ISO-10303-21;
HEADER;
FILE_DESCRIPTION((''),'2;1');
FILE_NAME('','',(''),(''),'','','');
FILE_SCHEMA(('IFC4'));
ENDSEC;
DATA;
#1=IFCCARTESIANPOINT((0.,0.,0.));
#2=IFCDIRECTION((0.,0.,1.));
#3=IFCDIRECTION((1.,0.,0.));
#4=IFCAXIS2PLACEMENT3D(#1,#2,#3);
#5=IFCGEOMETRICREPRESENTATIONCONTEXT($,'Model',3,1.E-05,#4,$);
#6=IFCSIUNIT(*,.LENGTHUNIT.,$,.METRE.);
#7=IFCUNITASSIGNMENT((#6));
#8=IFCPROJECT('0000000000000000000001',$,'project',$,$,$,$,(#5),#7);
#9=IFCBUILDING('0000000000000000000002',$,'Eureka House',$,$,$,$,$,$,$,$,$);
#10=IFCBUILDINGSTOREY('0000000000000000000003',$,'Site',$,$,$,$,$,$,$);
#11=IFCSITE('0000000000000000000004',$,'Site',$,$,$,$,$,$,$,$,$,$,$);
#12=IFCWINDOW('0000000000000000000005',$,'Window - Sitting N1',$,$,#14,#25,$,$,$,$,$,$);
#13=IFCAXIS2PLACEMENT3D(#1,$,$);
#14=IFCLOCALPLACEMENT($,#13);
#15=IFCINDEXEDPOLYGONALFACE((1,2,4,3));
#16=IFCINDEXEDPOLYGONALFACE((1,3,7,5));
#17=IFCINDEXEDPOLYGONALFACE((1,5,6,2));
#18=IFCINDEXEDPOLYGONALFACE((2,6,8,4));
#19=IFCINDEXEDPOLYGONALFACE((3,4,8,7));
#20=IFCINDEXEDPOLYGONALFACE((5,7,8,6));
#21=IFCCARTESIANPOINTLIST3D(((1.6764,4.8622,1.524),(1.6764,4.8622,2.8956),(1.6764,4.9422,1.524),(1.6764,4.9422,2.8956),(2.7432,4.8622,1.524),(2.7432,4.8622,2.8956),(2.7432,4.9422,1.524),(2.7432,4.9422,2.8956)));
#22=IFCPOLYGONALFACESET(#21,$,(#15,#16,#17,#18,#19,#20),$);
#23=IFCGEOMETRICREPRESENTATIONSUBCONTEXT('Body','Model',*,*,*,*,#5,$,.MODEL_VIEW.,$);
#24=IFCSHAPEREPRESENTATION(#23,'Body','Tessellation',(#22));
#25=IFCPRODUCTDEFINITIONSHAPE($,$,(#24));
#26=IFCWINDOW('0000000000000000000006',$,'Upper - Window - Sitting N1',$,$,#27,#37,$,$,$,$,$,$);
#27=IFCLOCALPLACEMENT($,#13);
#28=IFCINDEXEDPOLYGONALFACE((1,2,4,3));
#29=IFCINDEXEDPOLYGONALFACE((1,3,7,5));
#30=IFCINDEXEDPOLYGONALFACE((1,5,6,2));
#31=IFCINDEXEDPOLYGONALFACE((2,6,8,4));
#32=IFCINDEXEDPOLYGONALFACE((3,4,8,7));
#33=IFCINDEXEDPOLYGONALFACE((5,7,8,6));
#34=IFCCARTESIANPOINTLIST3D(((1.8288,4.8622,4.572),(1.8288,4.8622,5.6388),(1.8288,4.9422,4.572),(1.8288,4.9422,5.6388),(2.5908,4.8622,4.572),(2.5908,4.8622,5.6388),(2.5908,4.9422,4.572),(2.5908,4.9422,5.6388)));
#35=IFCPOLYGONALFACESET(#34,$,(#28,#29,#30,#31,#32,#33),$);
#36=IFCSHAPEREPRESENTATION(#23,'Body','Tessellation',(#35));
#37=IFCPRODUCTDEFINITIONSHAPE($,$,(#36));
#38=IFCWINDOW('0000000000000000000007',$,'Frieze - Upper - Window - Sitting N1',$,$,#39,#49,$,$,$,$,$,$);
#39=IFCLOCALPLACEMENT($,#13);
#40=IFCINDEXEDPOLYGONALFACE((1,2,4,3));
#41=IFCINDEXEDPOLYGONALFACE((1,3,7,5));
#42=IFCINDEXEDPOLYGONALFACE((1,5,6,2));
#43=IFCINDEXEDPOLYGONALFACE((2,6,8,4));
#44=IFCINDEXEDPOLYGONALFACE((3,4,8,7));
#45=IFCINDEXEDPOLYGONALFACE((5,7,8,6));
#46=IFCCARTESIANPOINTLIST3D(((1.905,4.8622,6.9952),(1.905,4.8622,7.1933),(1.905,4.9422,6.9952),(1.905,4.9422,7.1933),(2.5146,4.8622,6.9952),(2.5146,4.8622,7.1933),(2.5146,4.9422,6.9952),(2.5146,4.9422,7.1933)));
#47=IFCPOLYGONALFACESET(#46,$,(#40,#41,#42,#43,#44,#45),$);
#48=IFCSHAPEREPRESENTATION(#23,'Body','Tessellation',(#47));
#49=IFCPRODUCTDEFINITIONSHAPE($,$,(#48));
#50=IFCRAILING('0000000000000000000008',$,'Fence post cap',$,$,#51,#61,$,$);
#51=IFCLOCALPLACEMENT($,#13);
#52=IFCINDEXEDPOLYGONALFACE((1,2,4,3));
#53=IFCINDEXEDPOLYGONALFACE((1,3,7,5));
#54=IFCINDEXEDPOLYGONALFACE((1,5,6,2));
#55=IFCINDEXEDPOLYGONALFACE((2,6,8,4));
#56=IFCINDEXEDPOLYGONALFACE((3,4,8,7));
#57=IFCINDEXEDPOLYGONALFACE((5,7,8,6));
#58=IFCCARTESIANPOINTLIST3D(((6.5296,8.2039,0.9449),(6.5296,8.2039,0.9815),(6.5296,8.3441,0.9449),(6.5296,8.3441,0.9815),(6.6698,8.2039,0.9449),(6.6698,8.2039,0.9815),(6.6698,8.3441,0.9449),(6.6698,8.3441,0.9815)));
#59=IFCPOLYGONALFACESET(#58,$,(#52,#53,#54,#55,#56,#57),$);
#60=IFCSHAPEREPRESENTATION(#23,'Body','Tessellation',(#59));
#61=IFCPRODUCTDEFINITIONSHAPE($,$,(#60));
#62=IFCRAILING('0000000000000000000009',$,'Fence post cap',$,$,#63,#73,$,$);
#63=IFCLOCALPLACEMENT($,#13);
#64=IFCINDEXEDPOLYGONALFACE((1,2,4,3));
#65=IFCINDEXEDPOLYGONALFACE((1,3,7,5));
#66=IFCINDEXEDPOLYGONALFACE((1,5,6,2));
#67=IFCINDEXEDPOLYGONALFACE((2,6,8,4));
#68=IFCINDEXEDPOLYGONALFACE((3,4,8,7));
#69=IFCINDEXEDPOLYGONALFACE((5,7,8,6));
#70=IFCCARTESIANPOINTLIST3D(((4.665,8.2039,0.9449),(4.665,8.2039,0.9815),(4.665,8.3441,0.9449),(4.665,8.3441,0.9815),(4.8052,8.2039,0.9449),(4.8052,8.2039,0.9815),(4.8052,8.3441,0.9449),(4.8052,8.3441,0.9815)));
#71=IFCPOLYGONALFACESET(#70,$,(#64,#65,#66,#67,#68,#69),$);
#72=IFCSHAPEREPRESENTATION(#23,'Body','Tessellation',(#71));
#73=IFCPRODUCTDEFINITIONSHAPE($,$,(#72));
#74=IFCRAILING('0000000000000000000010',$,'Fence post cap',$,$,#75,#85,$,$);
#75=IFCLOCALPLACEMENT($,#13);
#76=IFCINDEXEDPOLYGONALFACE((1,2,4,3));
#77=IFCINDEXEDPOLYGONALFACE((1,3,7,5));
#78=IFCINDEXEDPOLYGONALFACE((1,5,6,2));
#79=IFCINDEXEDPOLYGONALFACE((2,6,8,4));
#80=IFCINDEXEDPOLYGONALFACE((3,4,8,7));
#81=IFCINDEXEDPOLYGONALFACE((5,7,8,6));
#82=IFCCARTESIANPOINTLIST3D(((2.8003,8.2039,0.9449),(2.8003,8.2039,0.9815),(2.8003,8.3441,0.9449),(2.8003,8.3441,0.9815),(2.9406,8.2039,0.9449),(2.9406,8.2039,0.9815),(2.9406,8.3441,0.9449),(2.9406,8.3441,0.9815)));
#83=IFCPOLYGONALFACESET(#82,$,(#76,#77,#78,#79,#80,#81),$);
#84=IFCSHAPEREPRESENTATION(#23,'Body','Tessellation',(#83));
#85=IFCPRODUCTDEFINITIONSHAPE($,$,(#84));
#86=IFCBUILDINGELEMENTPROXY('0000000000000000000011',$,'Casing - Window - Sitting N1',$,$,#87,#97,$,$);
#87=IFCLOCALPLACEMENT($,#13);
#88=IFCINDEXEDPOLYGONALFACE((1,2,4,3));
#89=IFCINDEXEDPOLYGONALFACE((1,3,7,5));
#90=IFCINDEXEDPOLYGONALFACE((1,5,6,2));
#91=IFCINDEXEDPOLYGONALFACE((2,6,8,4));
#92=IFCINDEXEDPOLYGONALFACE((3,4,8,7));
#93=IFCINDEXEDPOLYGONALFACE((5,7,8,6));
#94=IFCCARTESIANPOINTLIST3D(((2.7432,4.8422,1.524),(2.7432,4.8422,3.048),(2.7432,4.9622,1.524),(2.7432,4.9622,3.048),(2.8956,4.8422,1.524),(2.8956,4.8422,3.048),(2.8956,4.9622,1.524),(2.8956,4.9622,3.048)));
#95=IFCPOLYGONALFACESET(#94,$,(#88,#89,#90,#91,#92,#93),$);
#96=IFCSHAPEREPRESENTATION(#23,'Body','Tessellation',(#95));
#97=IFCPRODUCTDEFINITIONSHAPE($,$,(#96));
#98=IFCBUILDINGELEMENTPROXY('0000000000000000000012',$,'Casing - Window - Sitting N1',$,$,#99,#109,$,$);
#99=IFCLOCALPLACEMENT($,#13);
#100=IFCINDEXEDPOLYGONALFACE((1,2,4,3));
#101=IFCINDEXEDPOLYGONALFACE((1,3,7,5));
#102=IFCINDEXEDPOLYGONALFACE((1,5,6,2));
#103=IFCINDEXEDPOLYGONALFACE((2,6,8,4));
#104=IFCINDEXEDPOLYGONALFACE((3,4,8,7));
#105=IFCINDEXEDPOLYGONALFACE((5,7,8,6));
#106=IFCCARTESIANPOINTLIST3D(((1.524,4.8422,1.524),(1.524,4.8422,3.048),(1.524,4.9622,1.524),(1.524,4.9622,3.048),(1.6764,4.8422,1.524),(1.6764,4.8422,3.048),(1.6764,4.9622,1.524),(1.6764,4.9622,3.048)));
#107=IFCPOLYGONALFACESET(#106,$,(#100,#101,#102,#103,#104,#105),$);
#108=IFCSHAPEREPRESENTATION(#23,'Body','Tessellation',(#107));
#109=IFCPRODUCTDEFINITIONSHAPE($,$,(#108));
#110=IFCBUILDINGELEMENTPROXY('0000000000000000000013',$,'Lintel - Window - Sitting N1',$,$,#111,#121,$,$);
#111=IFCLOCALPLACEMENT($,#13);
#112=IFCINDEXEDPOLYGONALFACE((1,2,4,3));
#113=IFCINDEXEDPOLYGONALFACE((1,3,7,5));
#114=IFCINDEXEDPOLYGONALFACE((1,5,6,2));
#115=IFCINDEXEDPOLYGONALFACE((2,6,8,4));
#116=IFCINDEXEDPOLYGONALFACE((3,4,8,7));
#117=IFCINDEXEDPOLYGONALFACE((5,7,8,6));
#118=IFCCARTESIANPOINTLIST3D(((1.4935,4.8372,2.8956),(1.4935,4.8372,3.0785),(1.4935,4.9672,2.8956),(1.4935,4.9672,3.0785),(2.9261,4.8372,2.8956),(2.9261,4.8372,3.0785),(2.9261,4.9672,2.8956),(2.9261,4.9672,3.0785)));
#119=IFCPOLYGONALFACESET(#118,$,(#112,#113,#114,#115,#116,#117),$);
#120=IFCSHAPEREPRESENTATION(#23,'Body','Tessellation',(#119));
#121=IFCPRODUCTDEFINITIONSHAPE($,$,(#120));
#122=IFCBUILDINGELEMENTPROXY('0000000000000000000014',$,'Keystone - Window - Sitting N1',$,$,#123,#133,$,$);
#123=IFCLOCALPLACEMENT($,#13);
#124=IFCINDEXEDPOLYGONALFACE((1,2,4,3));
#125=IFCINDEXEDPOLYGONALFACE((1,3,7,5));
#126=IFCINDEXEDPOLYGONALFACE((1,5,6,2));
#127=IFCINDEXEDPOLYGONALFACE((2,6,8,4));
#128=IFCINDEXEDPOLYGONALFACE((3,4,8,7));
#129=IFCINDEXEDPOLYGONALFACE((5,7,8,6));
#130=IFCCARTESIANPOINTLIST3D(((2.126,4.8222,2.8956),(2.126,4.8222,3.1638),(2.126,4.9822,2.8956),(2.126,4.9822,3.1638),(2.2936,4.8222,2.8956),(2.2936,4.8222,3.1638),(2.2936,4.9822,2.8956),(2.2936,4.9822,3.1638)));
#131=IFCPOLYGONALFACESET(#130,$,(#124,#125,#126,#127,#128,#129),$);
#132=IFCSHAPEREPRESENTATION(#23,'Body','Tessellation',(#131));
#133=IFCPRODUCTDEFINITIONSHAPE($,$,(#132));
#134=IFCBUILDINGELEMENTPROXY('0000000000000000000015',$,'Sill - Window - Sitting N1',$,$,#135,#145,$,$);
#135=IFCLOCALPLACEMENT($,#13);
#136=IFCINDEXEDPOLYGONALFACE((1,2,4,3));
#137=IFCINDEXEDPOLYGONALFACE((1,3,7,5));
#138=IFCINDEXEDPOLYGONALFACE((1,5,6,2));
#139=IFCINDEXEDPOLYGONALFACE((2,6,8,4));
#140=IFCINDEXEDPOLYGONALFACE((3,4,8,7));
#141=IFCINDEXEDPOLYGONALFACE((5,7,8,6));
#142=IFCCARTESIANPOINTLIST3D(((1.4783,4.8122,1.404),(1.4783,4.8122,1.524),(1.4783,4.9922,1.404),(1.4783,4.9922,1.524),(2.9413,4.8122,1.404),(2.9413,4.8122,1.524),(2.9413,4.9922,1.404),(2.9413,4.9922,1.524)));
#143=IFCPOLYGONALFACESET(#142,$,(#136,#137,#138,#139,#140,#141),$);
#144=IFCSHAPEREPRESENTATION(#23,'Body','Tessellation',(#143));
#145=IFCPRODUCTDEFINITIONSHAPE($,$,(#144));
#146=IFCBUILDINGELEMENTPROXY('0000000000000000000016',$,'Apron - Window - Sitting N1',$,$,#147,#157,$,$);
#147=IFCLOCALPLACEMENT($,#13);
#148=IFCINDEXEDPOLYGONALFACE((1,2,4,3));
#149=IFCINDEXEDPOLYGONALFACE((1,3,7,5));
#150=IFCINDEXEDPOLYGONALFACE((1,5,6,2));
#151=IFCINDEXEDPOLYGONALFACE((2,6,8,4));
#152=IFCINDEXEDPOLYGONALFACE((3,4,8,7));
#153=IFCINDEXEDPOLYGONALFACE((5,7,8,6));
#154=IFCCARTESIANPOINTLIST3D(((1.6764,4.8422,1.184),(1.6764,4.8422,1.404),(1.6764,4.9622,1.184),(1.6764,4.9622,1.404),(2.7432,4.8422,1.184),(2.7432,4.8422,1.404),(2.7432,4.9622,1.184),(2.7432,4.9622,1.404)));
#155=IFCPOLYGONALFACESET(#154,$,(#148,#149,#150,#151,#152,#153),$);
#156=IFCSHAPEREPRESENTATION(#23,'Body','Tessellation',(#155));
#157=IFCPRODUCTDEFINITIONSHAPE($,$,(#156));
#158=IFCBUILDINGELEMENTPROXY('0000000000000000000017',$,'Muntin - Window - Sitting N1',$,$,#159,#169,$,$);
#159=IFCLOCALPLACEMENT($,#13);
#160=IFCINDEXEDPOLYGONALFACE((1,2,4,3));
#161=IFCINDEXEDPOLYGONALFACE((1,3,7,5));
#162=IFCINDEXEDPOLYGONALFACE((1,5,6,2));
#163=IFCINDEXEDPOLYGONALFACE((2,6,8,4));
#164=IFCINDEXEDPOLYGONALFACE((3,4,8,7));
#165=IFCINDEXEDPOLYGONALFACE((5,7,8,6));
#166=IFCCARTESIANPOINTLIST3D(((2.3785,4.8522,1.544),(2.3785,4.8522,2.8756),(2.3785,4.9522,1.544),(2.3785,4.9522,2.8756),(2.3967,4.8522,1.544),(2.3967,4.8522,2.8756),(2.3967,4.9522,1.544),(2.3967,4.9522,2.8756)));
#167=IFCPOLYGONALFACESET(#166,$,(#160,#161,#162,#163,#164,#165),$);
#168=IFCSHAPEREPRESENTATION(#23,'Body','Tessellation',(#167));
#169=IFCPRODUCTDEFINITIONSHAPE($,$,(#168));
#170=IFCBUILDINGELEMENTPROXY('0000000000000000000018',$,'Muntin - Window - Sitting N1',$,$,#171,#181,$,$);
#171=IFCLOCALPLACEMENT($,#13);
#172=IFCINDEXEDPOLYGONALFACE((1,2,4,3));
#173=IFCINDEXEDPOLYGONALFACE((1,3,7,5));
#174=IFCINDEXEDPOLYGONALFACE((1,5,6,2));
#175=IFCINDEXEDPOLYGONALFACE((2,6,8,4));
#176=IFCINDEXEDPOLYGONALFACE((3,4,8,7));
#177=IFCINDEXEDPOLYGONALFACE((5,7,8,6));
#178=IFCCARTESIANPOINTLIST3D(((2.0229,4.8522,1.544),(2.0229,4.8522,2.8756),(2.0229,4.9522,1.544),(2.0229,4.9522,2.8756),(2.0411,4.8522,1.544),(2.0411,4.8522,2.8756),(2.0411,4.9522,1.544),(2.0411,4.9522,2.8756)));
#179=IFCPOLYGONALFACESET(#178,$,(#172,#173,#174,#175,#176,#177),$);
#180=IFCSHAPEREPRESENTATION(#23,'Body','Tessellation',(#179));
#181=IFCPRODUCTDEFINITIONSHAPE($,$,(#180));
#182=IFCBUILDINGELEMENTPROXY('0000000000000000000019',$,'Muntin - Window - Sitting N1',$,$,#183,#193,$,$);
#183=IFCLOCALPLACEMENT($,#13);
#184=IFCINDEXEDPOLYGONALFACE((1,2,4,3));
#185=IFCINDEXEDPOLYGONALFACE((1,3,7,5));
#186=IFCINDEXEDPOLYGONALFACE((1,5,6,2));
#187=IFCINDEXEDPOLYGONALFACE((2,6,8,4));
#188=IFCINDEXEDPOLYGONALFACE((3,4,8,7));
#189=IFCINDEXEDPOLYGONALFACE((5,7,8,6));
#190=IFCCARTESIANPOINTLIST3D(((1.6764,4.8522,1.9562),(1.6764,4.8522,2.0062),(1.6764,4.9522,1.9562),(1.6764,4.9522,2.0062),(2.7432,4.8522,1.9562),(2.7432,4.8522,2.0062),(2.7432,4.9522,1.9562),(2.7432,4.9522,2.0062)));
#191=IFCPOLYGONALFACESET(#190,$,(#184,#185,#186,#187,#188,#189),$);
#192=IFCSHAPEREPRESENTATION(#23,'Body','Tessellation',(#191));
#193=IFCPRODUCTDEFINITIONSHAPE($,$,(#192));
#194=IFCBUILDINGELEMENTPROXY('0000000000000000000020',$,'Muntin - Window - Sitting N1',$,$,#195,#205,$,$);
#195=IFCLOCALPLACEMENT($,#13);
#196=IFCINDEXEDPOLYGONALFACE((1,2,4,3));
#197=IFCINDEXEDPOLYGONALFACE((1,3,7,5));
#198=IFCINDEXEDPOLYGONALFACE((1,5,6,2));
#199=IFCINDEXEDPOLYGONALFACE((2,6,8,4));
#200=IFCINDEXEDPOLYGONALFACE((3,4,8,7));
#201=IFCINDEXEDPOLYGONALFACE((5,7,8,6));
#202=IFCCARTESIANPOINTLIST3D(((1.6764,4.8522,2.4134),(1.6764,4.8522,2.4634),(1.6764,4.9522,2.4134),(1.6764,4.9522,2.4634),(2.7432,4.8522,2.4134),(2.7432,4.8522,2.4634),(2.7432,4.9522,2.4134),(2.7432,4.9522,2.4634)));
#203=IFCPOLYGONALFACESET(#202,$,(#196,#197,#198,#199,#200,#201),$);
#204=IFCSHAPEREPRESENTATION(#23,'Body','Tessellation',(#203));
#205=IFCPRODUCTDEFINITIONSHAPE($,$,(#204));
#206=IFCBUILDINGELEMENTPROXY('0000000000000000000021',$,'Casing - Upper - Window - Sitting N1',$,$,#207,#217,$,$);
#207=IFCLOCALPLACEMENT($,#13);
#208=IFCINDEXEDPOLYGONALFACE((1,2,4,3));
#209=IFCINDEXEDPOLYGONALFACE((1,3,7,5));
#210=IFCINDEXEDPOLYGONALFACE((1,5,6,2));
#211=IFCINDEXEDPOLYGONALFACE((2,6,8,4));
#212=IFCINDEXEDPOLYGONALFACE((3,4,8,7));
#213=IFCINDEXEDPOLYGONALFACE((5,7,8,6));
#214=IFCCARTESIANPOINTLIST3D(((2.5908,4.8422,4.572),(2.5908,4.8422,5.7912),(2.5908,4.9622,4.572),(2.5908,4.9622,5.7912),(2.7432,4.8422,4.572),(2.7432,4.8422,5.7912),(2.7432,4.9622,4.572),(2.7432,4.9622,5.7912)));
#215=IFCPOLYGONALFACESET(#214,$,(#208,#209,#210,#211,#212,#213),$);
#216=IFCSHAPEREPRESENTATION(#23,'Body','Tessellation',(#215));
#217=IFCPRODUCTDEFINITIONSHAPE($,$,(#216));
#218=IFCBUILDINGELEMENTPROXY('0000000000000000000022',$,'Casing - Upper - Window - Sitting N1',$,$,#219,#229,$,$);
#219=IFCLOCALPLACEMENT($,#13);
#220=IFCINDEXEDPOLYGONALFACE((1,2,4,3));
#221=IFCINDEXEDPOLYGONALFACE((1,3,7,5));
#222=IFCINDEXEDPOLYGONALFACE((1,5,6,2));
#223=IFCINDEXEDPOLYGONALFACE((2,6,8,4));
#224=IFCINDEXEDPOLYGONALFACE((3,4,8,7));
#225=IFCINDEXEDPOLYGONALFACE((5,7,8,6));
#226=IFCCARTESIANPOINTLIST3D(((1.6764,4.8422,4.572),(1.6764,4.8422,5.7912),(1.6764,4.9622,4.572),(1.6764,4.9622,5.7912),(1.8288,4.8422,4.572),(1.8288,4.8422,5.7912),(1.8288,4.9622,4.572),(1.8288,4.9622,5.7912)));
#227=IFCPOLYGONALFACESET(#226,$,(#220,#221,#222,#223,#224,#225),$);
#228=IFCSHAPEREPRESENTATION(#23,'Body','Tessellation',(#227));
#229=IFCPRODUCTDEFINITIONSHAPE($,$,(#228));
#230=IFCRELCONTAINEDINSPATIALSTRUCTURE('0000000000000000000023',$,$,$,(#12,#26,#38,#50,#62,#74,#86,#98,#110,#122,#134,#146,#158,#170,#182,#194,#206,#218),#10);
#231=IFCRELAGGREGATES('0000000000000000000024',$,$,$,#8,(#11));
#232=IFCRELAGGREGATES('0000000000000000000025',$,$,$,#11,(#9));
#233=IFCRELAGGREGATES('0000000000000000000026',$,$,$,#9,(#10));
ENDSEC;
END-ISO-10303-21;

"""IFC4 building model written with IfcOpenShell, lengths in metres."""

from ifc_helpers import new_model, si_unit, frame, origin, origin_with_axes, origin_2d, place, context, subcontext, project, spatial, rectangle, extrude, element, save


model = new_model("IFC4")

# Units and contexts
model_context = context("Model", 3, precision=1e-05, world=origin_with_axes())
body_context = subcontext(model_context, "Body", "Model", "MODEL_VIEW")
ifc_project = project(units=[si_unit("LENGTHUNIT", "METRE")], contexts=[model_context])

# Site, building, storey
site = spatial("IfcSite", under=ifc_project, Name="Site")
building = spatial("IfcBuilding", under=site, Name="Eureka House")
storey = spatial("IfcBuildingStorey", under=building, Name="Site")

# Windows
window_1_placement = place(None, frame((2.2098, 4.9022, 1.524), z_axis=(0.0, 0.0, 1.0), x_axis=(1.0, 0.0, 0.0)))
element("IfcWindow", 1, at=window_1_placement, inside=storey, Name="Window - Sitting N1", context=body_context, shape_type="SweptSolid", body=[
    extrude(rectangle(XDim=1.0668, YDim=0.08, at=origin_2d()), origin(), (0.0, 0.0, 1.0), 1.3716),
])
window_2_placement = place(None, frame((2.2098, 4.9022, 4.572), z_axis=(0.0, 0.0, 1.0), x_axis=(1.0, 0.0, 0.0)))
element("IfcWindow", 2, at=window_2_placement, inside=storey, Name="Upper - Window - Sitting N1", context=body_context, shape_type="SweptSolid", body=[
    extrude(rectangle(XDim=0.762, YDim=0.08, at=origin_2d()), origin(), (0.0, 0.0, 1.0), 1.0668),
])
window_3_placement = place(None, frame((2.2098, 4.9022, 6.9952), z_axis=(0.0, 0.0, 1.0), x_axis=(1.0, 0.0, 0.0)))
element("IfcWindow", 3, at=window_3_placement, inside=storey, Name="Frieze - Upper - Window - Sitting N1", context=body_context, shape_type="SweptSolid", body=[
    extrude(rectangle(XDim=0.6096, YDim=0.08, at=origin_2d()), origin(), (0.0, 0.0, 1.0), 0.1981),
])

# Railings
for number, where, z_axis, x_axis, name in (
    (4, (6.5997, 8.274, 0.9449), (0.0, 0.0, 1.0), (1.0, 0.0, 0.0), "Fence post cap"),
    (5, (4.7351, 8.274, 0.9449), (0.0, 0.0, 1.0), (1.0, 0.0, 0.0), "Fence post cap"),
    (6, (2.8705, 8.274, 0.9449), (0.0, 0.0, 1.0), (1.0, 0.0, 0.0), "Fence post cap"),
):
    element("IfcRailing", number, at=place(None, frame(where, z_axis=z_axis, x_axis=x_axis)), inside=storey, Name=name, context=body_context, shape_type="SweptSolid", body=[
        extrude(rectangle(XDim=0.1402, YDim=0.1402, at=origin_2d()), origin(), (0.0, 0.0, 1.0), 0.0366),
    ])

# Building element proxies
for number, where, z_axis, x_axis, name in (
    (7, (2.8194, 4.9022, 1.524), (0.0, 0.0, 1.0), (1.0, 0.0, 0.0), "Casing - Window - Sitting N1"),
    (8, (1.6002, 4.9022, 1.524), (0.0, 0.0, 1.0), (1.0, 0.0, 0.0), "Casing - Window - Sitting N1"),
):
    element("IfcBuildingElementProxy", number, at=place(None, frame(where, z_axis=z_axis, x_axis=x_axis)), inside=storey, Name=name, context=body_context, shape_type="SweptSolid", body=[
        extrude(rectangle(XDim=0.1524, YDim=0.12, at=origin_2d()), origin(), (0.0, 0.0, 1.0), 1.524),
    ])
proxy_1_placement = place(None, frame((2.2098, 4.9022, 2.8956), z_axis=(0.0, 0.0, 1.0), x_axis=(1.0, 0.0, 0.0)))
element("IfcBuildingElementProxy", 9, at=proxy_1_placement, inside=storey, Name="Lintel - Window - Sitting N1", context=body_context, shape_type="SweptSolid", body=[
    extrude(rectangle(XDim=1.4326, YDim=0.13, at=origin_2d()), origin(), (0.0, 0.0, 1.0), 0.1829),
])
proxy_2_placement = place(None, frame((2.2098, 4.9022, 2.8956), z_axis=(0.0, 0.0, 1.0), x_axis=(1.0, 0.0, 0.0)))
element("IfcBuildingElementProxy", 10, at=proxy_2_placement, inside=storey, Name="Keystone - Window - Sitting N1", context=body_context, shape_type="SweptSolid", body=[
    extrude(rectangle(XDim=0.1676, YDim=0.16, at=origin_2d()), origin(), (0.0, 0.0, 1.0), 0.2682),
])
proxy_3_placement = place(None, frame((2.2098, 4.9022, 1.404), z_axis=(0.0, 0.0, 1.0), x_axis=(1.0, 0.0, 0.0)))
element("IfcBuildingElementProxy", 11, at=proxy_3_placement, inside=storey, Name="Sill - Window - Sitting N1", context=body_context, shape_type="SweptSolid", body=[
    extrude(rectangle(XDim=1.463, YDim=0.18, at=origin_2d()), origin(), (0.0, 0.0, 1.0), 0.12),
])
proxy_4_placement = place(None, frame((2.2098, 4.9022, 1.184), z_axis=(0.0, 0.0, 1.0), x_axis=(1.0, 0.0, 0.0)))
element("IfcBuildingElementProxy", 12, at=proxy_4_placement, inside=storey, Name="Apron - Window - Sitting N1", context=body_context, shape_type="SweptSolid", body=[
    extrude(rectangle(XDim=1.0668, YDim=0.12, at=origin_2d()), origin(), (0.0, 0.0, 1.0), 0.22),
])
for number, where, z_axis, x_axis, name in (
    (13, (2.3876, 4.9022, 1.544), (0.0, 0.0, 1.0), (1.0, 0.0, 0.0), "Muntin - Window - Sitting N1"),
    (14, (2.032, 4.9022, 1.544), (0.0, 0.0, 1.0), (1.0, 0.0, 0.0), "Muntin - Window - Sitting N1"),
):
    element("IfcBuildingElementProxy", number, at=place(None, frame(where, z_axis=z_axis, x_axis=x_axis)), inside=storey, Name=name, context=body_context, shape_type="SweptSolid", body=[
        extrude(rectangle(XDim=0.0183, YDim=0.1, at=origin_2d()), origin(), (0.0, 0.0, 1.0), 1.3316),
    ])
proxy_5_placement = place(None, frame((2.2098, 4.9022, 1.9562), z_axis=(0.0, 0.0, 1.0), x_axis=(1.0, 0.0, 0.0)))
element("IfcBuildingElementProxy", 15, at=proxy_5_placement, inside=storey, Name="Muntin - Window - Sitting N1", context=body_context, shape_type="SweptSolid", body=[
    extrude(rectangle(XDim=1.0668, YDim=0.1, at=origin_2d()), origin(), (0.0, 0.0, 1.0), 0.05),
])
proxy_6_placement = place(None, frame((2.2098, 4.9022, 2.4134), z_axis=(0.0, 0.0, 1.0), x_axis=(1.0, 0.0, 0.0)))
element("IfcBuildingElementProxy", 16, at=proxy_6_placement, inside=storey, Name="Muntin - Window - Sitting N1", context=body_context, shape_type="SweptSolid", body=[
    extrude(rectangle(XDim=1.0668, YDim=0.1, at=origin_2d()), origin(), (0.0, 0.0, 1.0), 0.05),
])
for number, where, z_axis, x_axis, name in (
    (17, (2.667, 4.9022, 4.572), (0.0, 0.0, 1.0), (1.0, 0.0, 0.0), "Casing - Upper - Window - Sitting N1"),
    (18, (1.7526, 4.9022, 4.572), (0.0, 0.0, 1.0), (1.0, 0.0, 0.0), "Casing - Upper - Window - Sitting N1"),
):
    element("IfcBuildingElementProxy", number, at=place(None, frame(where, z_axis=z_axis, x_axis=x_axis)), inside=storey, Name=name, context=body_context, shape_type="SweptSolid", body=[
        extrude(rectangle(XDim=0.1524, YDim=0.12, at=origin_2d()), origin(), (0.0, 0.0, 1.0), 1.2192),
    ])

save(model, "model.ifc")
